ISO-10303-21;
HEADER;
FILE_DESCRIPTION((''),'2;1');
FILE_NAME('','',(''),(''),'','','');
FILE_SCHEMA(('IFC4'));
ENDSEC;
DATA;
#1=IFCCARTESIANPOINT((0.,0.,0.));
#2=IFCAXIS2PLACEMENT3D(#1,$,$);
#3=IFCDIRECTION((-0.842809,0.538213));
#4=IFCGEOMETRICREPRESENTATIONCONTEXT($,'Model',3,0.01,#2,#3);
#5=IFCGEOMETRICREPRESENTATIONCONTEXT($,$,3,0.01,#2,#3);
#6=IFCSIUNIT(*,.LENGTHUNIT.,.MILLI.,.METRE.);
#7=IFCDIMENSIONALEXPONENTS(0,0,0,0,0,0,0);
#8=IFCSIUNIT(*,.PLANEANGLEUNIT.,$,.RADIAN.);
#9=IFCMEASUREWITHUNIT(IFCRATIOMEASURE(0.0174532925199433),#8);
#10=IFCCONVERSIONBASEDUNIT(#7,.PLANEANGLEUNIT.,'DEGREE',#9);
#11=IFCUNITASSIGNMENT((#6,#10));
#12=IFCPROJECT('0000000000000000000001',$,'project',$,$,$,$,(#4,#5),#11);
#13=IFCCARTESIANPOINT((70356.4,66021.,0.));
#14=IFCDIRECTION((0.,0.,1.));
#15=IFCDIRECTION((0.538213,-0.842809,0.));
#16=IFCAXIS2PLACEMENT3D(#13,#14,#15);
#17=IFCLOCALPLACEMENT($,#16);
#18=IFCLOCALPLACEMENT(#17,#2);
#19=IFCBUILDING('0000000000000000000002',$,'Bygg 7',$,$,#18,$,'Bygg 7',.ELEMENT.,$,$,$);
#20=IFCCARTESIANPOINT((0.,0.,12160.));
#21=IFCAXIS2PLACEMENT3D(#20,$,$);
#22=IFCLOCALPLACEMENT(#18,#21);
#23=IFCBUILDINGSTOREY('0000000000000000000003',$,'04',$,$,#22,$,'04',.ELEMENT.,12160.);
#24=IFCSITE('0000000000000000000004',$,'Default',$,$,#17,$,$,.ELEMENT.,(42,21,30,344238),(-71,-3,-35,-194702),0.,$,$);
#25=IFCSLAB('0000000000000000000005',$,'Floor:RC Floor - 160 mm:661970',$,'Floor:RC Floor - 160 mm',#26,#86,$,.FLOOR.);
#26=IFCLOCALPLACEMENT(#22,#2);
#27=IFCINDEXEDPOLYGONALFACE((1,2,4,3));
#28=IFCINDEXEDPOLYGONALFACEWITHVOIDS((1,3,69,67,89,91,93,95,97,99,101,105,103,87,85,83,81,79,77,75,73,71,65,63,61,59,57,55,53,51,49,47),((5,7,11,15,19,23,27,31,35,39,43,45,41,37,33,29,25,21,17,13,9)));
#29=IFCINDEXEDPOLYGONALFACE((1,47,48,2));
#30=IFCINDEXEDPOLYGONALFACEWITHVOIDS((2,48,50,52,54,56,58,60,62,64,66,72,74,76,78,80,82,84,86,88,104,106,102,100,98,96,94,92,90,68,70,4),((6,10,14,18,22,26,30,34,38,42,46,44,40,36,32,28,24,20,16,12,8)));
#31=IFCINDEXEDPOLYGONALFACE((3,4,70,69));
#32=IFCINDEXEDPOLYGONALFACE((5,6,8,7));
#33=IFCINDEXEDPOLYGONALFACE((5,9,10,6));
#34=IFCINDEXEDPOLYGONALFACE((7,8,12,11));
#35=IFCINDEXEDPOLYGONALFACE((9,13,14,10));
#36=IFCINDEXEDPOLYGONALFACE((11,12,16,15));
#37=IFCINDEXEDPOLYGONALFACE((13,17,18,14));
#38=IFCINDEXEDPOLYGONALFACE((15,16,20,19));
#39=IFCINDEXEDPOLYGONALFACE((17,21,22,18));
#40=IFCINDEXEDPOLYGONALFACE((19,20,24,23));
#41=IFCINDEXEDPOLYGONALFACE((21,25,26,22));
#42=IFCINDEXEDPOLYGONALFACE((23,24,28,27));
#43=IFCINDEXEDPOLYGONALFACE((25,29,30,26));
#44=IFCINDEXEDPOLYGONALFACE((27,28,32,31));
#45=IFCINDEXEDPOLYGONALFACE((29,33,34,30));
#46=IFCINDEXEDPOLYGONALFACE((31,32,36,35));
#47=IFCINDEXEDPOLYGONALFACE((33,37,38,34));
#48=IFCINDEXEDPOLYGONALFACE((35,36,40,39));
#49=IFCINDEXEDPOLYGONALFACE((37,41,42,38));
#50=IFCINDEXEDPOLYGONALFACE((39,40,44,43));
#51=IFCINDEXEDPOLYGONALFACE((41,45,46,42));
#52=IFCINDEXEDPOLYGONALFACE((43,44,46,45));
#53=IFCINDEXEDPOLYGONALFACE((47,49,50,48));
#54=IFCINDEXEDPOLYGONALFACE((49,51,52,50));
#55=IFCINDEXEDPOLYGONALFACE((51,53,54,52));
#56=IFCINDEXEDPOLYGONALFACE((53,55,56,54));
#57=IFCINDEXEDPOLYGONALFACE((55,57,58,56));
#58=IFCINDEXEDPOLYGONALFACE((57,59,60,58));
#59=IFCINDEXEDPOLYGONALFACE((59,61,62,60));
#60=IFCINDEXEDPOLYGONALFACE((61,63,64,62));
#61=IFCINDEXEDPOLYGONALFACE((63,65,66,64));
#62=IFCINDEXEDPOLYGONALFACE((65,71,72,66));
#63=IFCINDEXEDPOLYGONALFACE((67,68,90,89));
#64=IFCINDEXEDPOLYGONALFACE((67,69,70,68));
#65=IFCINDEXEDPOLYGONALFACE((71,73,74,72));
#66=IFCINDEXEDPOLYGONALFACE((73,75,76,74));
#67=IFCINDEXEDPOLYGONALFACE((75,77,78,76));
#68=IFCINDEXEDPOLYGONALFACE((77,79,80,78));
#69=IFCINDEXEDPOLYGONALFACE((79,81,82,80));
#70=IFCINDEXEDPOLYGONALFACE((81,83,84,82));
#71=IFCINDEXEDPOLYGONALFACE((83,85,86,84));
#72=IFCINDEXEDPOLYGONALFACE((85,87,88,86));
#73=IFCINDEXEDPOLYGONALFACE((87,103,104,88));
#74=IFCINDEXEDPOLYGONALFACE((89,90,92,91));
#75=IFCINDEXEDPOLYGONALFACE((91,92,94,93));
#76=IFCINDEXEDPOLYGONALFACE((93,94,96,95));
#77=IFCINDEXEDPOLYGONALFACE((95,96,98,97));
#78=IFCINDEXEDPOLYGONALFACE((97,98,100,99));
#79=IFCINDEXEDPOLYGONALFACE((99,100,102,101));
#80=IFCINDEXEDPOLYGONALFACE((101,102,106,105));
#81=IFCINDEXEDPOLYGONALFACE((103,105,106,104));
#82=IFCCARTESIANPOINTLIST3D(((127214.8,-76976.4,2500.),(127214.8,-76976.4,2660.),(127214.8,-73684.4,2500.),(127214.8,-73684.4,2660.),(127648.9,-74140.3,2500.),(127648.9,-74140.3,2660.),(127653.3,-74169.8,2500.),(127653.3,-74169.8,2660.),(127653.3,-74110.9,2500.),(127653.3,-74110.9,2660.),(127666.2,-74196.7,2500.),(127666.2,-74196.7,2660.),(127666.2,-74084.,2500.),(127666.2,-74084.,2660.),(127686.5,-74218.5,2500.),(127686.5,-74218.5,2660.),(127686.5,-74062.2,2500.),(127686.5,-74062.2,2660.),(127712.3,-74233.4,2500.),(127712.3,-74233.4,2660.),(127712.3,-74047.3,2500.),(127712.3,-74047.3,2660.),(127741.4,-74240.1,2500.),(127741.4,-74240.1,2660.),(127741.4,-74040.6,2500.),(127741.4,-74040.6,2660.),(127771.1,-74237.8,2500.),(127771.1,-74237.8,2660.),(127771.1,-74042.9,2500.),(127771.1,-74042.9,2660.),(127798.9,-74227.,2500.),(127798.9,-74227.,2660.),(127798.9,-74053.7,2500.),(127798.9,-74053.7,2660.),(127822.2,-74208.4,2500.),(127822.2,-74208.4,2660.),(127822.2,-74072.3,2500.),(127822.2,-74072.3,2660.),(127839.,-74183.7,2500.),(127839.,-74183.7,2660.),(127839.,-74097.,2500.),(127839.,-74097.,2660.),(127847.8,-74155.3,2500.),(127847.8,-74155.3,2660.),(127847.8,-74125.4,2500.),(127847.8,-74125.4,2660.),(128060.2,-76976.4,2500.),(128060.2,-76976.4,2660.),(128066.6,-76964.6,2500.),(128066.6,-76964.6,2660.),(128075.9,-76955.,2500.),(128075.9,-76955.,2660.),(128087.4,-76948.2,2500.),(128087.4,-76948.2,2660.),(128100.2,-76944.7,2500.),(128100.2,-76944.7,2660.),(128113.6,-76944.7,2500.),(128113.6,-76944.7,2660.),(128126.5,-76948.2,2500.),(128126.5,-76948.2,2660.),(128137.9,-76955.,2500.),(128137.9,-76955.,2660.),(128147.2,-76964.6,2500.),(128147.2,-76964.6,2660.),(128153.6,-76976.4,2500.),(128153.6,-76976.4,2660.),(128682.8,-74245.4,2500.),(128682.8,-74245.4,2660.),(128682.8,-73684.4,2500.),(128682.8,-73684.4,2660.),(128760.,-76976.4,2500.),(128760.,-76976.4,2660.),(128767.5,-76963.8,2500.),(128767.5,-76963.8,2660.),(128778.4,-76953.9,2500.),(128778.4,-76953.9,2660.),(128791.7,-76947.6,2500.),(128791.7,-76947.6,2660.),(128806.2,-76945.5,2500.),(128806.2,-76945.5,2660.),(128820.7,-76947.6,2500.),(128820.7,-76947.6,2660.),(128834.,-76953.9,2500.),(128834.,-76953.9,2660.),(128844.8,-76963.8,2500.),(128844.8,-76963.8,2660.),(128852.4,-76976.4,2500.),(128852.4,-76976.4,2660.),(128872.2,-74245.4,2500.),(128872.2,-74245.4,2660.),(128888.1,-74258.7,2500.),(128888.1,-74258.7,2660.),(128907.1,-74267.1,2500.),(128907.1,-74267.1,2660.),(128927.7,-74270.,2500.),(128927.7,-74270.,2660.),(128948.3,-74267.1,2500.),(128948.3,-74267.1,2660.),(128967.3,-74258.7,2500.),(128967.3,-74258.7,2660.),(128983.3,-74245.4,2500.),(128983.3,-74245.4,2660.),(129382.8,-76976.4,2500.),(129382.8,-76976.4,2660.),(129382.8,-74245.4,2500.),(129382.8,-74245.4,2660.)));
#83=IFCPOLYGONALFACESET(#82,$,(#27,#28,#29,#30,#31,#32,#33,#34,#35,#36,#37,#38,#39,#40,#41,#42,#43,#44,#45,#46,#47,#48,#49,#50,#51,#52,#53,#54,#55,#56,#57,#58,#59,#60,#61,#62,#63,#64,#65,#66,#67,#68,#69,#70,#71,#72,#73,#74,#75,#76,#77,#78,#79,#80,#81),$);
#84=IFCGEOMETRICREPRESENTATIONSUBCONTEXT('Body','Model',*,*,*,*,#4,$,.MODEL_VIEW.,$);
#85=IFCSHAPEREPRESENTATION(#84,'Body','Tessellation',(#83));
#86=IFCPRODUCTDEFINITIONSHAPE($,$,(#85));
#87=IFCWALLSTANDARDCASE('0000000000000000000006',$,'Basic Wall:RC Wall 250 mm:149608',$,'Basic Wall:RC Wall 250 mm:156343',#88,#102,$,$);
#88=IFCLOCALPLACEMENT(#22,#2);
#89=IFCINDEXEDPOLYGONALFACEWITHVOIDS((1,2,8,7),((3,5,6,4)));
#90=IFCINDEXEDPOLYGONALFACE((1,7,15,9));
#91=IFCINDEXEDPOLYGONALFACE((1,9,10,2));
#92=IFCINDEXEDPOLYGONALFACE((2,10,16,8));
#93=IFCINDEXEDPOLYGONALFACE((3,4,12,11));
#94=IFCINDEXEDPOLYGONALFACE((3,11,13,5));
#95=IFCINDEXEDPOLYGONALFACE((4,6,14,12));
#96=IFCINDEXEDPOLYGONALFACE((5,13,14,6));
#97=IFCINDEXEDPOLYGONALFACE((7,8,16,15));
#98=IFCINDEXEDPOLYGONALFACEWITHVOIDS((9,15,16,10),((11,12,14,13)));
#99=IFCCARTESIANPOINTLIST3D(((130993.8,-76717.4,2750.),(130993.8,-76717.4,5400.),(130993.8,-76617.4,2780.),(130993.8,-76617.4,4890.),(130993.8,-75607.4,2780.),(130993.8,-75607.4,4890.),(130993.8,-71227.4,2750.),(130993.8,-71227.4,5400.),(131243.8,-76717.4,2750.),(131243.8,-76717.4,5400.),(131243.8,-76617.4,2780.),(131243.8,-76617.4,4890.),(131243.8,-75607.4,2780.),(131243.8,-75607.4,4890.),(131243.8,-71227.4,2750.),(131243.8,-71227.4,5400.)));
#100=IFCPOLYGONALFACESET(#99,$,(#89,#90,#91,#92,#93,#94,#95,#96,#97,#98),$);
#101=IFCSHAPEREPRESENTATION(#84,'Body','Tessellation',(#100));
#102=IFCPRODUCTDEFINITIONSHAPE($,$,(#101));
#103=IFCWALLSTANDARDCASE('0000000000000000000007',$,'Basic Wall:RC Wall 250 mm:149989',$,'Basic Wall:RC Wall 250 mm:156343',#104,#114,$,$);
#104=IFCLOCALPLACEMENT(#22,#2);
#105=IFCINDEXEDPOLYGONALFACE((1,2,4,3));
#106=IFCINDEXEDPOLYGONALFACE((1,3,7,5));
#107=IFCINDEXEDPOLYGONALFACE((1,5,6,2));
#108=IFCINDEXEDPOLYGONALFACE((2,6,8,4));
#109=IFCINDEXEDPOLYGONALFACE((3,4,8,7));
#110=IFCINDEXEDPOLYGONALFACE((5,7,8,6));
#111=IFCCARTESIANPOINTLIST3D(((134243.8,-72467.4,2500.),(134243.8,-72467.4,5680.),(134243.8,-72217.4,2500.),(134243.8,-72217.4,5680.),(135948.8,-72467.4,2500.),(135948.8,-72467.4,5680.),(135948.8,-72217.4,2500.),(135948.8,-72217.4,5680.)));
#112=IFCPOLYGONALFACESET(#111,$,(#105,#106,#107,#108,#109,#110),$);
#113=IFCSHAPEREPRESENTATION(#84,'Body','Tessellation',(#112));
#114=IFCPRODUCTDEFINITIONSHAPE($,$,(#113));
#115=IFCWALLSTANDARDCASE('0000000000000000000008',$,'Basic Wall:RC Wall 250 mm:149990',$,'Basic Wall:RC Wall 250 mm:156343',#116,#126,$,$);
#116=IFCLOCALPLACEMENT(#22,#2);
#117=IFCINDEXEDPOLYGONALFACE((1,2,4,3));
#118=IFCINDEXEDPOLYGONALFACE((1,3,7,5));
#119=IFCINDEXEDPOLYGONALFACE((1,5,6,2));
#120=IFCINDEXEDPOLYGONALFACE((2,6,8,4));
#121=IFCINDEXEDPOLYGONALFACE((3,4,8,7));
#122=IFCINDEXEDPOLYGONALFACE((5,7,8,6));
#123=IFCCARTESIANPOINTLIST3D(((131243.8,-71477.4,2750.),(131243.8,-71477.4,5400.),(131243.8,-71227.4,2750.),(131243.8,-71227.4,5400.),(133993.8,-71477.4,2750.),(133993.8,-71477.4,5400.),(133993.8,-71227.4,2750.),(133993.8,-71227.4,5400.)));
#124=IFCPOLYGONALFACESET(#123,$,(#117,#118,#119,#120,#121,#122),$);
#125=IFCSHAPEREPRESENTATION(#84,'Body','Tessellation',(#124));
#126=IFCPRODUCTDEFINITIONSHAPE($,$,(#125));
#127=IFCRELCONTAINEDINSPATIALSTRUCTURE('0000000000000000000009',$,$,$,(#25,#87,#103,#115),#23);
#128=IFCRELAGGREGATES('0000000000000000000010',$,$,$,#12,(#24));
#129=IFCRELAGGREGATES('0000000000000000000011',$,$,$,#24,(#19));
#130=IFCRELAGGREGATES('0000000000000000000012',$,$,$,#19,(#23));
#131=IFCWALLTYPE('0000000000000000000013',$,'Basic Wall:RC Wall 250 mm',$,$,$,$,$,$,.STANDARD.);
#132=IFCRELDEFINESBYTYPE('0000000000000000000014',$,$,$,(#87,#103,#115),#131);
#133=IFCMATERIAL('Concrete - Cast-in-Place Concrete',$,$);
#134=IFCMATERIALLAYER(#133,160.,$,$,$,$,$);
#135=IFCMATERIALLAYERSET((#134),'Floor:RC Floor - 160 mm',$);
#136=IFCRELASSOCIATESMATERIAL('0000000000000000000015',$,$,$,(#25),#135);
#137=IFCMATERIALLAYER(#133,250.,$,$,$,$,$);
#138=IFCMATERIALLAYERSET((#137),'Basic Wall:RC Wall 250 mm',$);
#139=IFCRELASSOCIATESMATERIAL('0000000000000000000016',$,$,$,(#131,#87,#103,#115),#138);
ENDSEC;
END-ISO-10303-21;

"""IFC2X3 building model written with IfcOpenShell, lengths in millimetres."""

from ifc_helpers import new_model, entity, si_unit, converted_unit, direction, frame, frame_2d, origin, origin_2d_with_axis, place, context, subcontext, project, spatial, polyline, rectangle, circle, outline, extrude, clip, bounded_halfspace, material, layer, layer_set, layer_usage, type_object, element, save


model = new_model("IFC2X3")

# Units and contexts
model_context = context("Model", 3, precision=0.01, world=origin(), true_north=direction((-0.842809, 0.538213)))
context_of_model = context(None, 3, precision=0.01, world=origin(), true_north=direction((-0.842809, 0.538213)))
body_context = subcontext(model_context, "Body", "Model", "MODEL_VIEW")
ifc_project = project(units=[si_unit("LENGTHUNIT", "METRE", prefix="MILLI"), converted_unit("PLANEANGLEUNIT", "DEGREE", entity("IfcRatioMeasure", 0.0174532925199433), si_unit("PLANEANGLEUNIT", "RADIAN"), dimensions=[0, 0, 0, 0, 0, 0, 0])], contexts=[model_context, context_of_model])

# Site, building, storey
site_placement = place(None, frame((70356.4, 66021.0, 0.0), z_axis=(0.0, 0.0, 1.0), x_axis=(0.538213, -0.842809, 0.0)))
site = spatial("IfcSite", under=ifc_project, at=site_placement, Name="Default", CompositionType="ELEMENT", RefLatitude=(42, 21, 30, 344238), RefLongitude=(-71, -3, -35, -194702), RefElevation=0.0)
building_placement = place(site_placement, origin())
building = spatial("IfcBuilding", under=site, at=building_placement, Name="Bygg 7", LongName="Bygg 7", CompositionType="ELEMENT")
storey_placement = place(building_placement, frame((0.0, 0.0, 12160.0)))
storey = spatial("IfcBuildingStorey", under=building, at=storey_placement, Name="04", LongName="04", CompositionType="ELEMENT", Elevation=12160.0)

# Shared definitions
ifc_material_1 = material(Name="Concrete - Cast-in-Place Concrete")

# Slab, openings
ifc_layer_1 = layer(ifc_material_1, 160.0)
ifc_layer_set_1 = layer_set([ifc_layer_1], Name="Floor:RC Floor - 160 mm")
ifc_layer_usage_1 = layer_usage(ifc_layer_set_1, "AXIS3", "POSITIVE", 0.0)
slab_1_placement = place(storey_placement, frame((127214.8, -76976.4, 2500.0)))
slab_1 = element("IfcSlab", 1, at=slab_1_placement, inside=storey, material=ifc_layer_usage_1, Name="Floor:RC Floor - 160 mm:661970", ObjectType="Floor:RC Floor - 160 mm", PredefinedType="FLOOR", context=body_context, shape_type="SweptSolid", body=[
    extrude(outline(polyline([(1084.0, 1646.0), (-384.0, 1646.0), (-384.0, 1085.0), (-1084.0, 1085.0), (-1084.0, -1646.0), (1084.0, -1646.0), (1084.0, 1646.0)])), frame((1084.0, 1646.0, 160.0), z_axis=(0.0, 0.0, -1.0), x_axis=(-1.0, 0.0, 0.0)), (0.0, 0.0, 1.0), 160.0),
])
opening_1_placement = place(storey_placement, frame((127214.8, -76976.4, 2500.0)))
element("IfcOpeningElement", 2, at=opening_1_placement, cuts=slab_1, ObjectType="Opening", context=body_context, shape_type="SweptSolid", body=[
    extrude(circle(Radius=100.0, at=frame_2d((550.0, 1190.0), x_axis=(1.0, 0.0))), frame((1084.0, 1646.0, 160.0), z_axis=(0.0, 0.0, -1.0), x_axis=(-1.0, 0.0, 0.0)), (0.0, 0.0, 1.0), 160.0),
])
opening_2_placement = place(storey_placement, frame((127214.8, -76976.4, 2500.0)))
element("IfcOpeningElement", 3, at=opening_2_placement, cuts=slab_1, ObjectType="Opening", context=body_context, shape_type="SweptSolid", body=[
    extrude(circle(Radius=75.0, at=frame_2d((-628.9, 1135.4), x_axis=(1.0, 0.0))), frame((1084.0, 1646.0, 160.0), z_axis=(0.0, 0.0, -1.0), x_axis=(-1.0, 0.0, 0.0)), (0.0, 0.0, 1.0), 160.0),
])
opening_3_placement = place(storey_placement, frame((127214.8, -76976.4, 2500.0)))
element("IfcOpeningElement", 4, at=opening_3_placement, cuts=slab_1, ObjectType="Opening", context=body_context, shape_type="SweptSolid", body=[
    extrude(circle(Radius=50.0, at=frame_2d((191.9, -1663.9), x_axis=(1.0, 0.0))), frame((1084.0, 1646.0, 160.0), z_axis=(0.0, 0.0, -1.0), x_axis=(-1.0, 0.0, 0.0)), (0.0, 0.0, 1.0), 160.0),
])
opening_4_placement = place(storey_placement, frame((127214.8, -76976.4, 2500.0)))
element("IfcOpeningElement", 5, at=opening_4_placement, cuts=slab_1, ObjectType="Opening", context=body_context, shape_type="SweptSolid", body=[
    extrude(circle(Radius=50.0, at=frame_2d((-507.4, -1665.1), x_axis=(1.0, 0.0))), frame((1084.0, 1646.0, 160.0), z_axis=(0.0, 0.0, -1.0), x_axis=(-1.0, 0.0, 0.0)), (0.0, 0.0, 1.0), 160.0),
])

# Wall, opening
ifc_layer_2 = layer(ifc_material_1, 250.0)
ifc_layer_set_2 = layer_set([ifc_layer_2], Name="Basic Wall:RC Wall 250 mm")
wall_type_1 = type_object("IfcWallType", Name="Basic Wall:RC Wall 250 mm", PredefinedType="STANDARD", material=ifc_layer_set_2)
ifc_layer_usage_2 = layer_usage(ifc_layer_set_2, "AXIS2", "NEGATIVE", 125.0)
wall_1_placement = place(storey_placement, frame((131118.8, -76717.4, 2750.0), z_axis=(0.0, 0.0, 1.0), x_axis=(0.0, 1.0, 0.0)))
wall_1 = element("IfcWallStandardCase", 6, at=wall_1_placement, inside=storey, type_object=wall_type_1, material=ifc_layer_usage_2, Name="Basic Wall:RC Wall 250 mm:149608", ObjectType="Basic Wall:RC Wall 250 mm:156343", context=body_context, shape_type="Clipping", body=[
    clip(clip(clip(extrude(rectangle(XDim=5490.0, YDim=250.0, at=frame_2d((2745.0, 0.0), x_axis=(-1.0, 0.0))), origin(), (0.0, 0.0, 1.0), 2650.0), bounded_halfspace(frame((0.0, -125.0, 2650.0), z_axis=(0.0, 0.0, -1.0), x_axis=(-0.99571, -0.092529, 0.0)), True, frame((0.0, -125.0, 2650.0)), polyline([(0.0, 0.0), (5240.1, 0.0), (5490.0, 0.0), (5490.0, 250.0), (0.0, 250.0), (0.0, 0.0)]))), bounded_halfspace(frame((0.0, -125.0, 0.0), z_axis=(0.0, 0.0, 1.0), x_axis=(0.99571, 0.092529, 0.0)), True, frame((0.0, -125.0, 0.0)), polyline([(0.0, 0.0), (100.0, 0.0), (100.0, 250.0), (0.0, 250.0), (0.0, 0.0)]))), bounded_halfspace(frame((5490.0, 125.0, 0.0), z_axis=(0.0, 0.0, 1.0), x_axis=(0.99571, 0.092529, 0.0)), True, frame((5490.0, 125.0, 0.0)), polyline([(0.0, 0.0), (-4380.0, 0.0), (-4380.0, -250.0), (-249.9, -250.0), (0.0, -250.0), (0.0, 0.0)]))),
])
opening_5_placement = place(wall_1_placement, origin())
element("IfcOpeningElement", 7, at=opening_5_placement, cuts=wall_1, ObjectType="Opening", context=body_context, shape_type="SweptSolid", body=[
    extrude(rectangle(XDim=2110.0, YDim=1010.0, at=origin_2d_with_axis()), frame((605.0, -125.0, 1085.0), z_axis=(0.0, 1.0, 0.0), x_axis=(0.0, 0.0, -1.0)), (0.0, 0.0, 1.0), 250.0),
])

# Walls
ifc_layer_usage_3 = layer_usage(ifc_layer_set_2, "AXIS2", "NEGATIVE", 125.0)
wall_2_placement = place(storey_placement, frame((134243.8, -72342.4, 2500.0)))
element("IfcWallStandardCase", 8, at=wall_2_placement, inside=storey, type_object=wall_type_1, material=ifc_layer_usage_3, Name="Basic Wall:RC Wall 250 mm:149989", ObjectType="Basic Wall:RC Wall 250 mm:156343", context=body_context, shape_type="SweptSolid", body=[
    extrude(rectangle(XDim=1705.0, YDim=250.0, at=frame_2d((852.5, 0.0), x_axis=(-1.0, 0.0))), origin(), (0.0, 0.0, 1.0), 3180.0),
])
ifc_layer_usage_4 = layer_usage(ifc_layer_set_2, "AXIS2", "NEGATIVE", 125.0)
wall_3_placement = place(storey_placement, frame((131243.8, -71352.4, 2750.0)))
element("IfcWallStandardCase", 9, at=wall_3_placement, inside=storey, type_object=wall_type_1, material=ifc_layer_usage_4, Name="Basic Wall:RC Wall 250 mm:149990", ObjectType="Basic Wall:RC Wall 250 mm:156343", context=body_context, shape_type="Clipping", body=[
    clip(clip(extrude(rectangle(XDim=2750.0, YDim=250.0, at=frame_2d((1375.0, 0.0), x_axis=(-1.0, 0.0))), origin(), (0.0, 0.0, 1.0), 2650.0), bounded_halfspace(frame((0.0, -125.0, 2650.0), z_axis=(0.0, 0.0, -1.0), x_axis=(0.092529, -0.99571, 0.0)), True, frame((0.0, -125.0, 2650.0)), polyline([(0.0, 0.0), (2750.0, 0.0), (2750.0, 250.0), (0.0, 250.0), (0.0, 0.0)]))), bounded_halfspace(frame((2750.0, -125.0, 0.0), z_axis=(0.0, 0.0, 1.0), x_axis=(-0.092529, 0.99571, 0.0)), True, frame((2750.0, -125.0, 0.0)), polyline([(0.0, 0.0), (0.0, 250.0), (-2750.0, 250.0), (-2750.0, 0.0), (0.0, 0.0)]))),
])

save(model, "model.ifc")
